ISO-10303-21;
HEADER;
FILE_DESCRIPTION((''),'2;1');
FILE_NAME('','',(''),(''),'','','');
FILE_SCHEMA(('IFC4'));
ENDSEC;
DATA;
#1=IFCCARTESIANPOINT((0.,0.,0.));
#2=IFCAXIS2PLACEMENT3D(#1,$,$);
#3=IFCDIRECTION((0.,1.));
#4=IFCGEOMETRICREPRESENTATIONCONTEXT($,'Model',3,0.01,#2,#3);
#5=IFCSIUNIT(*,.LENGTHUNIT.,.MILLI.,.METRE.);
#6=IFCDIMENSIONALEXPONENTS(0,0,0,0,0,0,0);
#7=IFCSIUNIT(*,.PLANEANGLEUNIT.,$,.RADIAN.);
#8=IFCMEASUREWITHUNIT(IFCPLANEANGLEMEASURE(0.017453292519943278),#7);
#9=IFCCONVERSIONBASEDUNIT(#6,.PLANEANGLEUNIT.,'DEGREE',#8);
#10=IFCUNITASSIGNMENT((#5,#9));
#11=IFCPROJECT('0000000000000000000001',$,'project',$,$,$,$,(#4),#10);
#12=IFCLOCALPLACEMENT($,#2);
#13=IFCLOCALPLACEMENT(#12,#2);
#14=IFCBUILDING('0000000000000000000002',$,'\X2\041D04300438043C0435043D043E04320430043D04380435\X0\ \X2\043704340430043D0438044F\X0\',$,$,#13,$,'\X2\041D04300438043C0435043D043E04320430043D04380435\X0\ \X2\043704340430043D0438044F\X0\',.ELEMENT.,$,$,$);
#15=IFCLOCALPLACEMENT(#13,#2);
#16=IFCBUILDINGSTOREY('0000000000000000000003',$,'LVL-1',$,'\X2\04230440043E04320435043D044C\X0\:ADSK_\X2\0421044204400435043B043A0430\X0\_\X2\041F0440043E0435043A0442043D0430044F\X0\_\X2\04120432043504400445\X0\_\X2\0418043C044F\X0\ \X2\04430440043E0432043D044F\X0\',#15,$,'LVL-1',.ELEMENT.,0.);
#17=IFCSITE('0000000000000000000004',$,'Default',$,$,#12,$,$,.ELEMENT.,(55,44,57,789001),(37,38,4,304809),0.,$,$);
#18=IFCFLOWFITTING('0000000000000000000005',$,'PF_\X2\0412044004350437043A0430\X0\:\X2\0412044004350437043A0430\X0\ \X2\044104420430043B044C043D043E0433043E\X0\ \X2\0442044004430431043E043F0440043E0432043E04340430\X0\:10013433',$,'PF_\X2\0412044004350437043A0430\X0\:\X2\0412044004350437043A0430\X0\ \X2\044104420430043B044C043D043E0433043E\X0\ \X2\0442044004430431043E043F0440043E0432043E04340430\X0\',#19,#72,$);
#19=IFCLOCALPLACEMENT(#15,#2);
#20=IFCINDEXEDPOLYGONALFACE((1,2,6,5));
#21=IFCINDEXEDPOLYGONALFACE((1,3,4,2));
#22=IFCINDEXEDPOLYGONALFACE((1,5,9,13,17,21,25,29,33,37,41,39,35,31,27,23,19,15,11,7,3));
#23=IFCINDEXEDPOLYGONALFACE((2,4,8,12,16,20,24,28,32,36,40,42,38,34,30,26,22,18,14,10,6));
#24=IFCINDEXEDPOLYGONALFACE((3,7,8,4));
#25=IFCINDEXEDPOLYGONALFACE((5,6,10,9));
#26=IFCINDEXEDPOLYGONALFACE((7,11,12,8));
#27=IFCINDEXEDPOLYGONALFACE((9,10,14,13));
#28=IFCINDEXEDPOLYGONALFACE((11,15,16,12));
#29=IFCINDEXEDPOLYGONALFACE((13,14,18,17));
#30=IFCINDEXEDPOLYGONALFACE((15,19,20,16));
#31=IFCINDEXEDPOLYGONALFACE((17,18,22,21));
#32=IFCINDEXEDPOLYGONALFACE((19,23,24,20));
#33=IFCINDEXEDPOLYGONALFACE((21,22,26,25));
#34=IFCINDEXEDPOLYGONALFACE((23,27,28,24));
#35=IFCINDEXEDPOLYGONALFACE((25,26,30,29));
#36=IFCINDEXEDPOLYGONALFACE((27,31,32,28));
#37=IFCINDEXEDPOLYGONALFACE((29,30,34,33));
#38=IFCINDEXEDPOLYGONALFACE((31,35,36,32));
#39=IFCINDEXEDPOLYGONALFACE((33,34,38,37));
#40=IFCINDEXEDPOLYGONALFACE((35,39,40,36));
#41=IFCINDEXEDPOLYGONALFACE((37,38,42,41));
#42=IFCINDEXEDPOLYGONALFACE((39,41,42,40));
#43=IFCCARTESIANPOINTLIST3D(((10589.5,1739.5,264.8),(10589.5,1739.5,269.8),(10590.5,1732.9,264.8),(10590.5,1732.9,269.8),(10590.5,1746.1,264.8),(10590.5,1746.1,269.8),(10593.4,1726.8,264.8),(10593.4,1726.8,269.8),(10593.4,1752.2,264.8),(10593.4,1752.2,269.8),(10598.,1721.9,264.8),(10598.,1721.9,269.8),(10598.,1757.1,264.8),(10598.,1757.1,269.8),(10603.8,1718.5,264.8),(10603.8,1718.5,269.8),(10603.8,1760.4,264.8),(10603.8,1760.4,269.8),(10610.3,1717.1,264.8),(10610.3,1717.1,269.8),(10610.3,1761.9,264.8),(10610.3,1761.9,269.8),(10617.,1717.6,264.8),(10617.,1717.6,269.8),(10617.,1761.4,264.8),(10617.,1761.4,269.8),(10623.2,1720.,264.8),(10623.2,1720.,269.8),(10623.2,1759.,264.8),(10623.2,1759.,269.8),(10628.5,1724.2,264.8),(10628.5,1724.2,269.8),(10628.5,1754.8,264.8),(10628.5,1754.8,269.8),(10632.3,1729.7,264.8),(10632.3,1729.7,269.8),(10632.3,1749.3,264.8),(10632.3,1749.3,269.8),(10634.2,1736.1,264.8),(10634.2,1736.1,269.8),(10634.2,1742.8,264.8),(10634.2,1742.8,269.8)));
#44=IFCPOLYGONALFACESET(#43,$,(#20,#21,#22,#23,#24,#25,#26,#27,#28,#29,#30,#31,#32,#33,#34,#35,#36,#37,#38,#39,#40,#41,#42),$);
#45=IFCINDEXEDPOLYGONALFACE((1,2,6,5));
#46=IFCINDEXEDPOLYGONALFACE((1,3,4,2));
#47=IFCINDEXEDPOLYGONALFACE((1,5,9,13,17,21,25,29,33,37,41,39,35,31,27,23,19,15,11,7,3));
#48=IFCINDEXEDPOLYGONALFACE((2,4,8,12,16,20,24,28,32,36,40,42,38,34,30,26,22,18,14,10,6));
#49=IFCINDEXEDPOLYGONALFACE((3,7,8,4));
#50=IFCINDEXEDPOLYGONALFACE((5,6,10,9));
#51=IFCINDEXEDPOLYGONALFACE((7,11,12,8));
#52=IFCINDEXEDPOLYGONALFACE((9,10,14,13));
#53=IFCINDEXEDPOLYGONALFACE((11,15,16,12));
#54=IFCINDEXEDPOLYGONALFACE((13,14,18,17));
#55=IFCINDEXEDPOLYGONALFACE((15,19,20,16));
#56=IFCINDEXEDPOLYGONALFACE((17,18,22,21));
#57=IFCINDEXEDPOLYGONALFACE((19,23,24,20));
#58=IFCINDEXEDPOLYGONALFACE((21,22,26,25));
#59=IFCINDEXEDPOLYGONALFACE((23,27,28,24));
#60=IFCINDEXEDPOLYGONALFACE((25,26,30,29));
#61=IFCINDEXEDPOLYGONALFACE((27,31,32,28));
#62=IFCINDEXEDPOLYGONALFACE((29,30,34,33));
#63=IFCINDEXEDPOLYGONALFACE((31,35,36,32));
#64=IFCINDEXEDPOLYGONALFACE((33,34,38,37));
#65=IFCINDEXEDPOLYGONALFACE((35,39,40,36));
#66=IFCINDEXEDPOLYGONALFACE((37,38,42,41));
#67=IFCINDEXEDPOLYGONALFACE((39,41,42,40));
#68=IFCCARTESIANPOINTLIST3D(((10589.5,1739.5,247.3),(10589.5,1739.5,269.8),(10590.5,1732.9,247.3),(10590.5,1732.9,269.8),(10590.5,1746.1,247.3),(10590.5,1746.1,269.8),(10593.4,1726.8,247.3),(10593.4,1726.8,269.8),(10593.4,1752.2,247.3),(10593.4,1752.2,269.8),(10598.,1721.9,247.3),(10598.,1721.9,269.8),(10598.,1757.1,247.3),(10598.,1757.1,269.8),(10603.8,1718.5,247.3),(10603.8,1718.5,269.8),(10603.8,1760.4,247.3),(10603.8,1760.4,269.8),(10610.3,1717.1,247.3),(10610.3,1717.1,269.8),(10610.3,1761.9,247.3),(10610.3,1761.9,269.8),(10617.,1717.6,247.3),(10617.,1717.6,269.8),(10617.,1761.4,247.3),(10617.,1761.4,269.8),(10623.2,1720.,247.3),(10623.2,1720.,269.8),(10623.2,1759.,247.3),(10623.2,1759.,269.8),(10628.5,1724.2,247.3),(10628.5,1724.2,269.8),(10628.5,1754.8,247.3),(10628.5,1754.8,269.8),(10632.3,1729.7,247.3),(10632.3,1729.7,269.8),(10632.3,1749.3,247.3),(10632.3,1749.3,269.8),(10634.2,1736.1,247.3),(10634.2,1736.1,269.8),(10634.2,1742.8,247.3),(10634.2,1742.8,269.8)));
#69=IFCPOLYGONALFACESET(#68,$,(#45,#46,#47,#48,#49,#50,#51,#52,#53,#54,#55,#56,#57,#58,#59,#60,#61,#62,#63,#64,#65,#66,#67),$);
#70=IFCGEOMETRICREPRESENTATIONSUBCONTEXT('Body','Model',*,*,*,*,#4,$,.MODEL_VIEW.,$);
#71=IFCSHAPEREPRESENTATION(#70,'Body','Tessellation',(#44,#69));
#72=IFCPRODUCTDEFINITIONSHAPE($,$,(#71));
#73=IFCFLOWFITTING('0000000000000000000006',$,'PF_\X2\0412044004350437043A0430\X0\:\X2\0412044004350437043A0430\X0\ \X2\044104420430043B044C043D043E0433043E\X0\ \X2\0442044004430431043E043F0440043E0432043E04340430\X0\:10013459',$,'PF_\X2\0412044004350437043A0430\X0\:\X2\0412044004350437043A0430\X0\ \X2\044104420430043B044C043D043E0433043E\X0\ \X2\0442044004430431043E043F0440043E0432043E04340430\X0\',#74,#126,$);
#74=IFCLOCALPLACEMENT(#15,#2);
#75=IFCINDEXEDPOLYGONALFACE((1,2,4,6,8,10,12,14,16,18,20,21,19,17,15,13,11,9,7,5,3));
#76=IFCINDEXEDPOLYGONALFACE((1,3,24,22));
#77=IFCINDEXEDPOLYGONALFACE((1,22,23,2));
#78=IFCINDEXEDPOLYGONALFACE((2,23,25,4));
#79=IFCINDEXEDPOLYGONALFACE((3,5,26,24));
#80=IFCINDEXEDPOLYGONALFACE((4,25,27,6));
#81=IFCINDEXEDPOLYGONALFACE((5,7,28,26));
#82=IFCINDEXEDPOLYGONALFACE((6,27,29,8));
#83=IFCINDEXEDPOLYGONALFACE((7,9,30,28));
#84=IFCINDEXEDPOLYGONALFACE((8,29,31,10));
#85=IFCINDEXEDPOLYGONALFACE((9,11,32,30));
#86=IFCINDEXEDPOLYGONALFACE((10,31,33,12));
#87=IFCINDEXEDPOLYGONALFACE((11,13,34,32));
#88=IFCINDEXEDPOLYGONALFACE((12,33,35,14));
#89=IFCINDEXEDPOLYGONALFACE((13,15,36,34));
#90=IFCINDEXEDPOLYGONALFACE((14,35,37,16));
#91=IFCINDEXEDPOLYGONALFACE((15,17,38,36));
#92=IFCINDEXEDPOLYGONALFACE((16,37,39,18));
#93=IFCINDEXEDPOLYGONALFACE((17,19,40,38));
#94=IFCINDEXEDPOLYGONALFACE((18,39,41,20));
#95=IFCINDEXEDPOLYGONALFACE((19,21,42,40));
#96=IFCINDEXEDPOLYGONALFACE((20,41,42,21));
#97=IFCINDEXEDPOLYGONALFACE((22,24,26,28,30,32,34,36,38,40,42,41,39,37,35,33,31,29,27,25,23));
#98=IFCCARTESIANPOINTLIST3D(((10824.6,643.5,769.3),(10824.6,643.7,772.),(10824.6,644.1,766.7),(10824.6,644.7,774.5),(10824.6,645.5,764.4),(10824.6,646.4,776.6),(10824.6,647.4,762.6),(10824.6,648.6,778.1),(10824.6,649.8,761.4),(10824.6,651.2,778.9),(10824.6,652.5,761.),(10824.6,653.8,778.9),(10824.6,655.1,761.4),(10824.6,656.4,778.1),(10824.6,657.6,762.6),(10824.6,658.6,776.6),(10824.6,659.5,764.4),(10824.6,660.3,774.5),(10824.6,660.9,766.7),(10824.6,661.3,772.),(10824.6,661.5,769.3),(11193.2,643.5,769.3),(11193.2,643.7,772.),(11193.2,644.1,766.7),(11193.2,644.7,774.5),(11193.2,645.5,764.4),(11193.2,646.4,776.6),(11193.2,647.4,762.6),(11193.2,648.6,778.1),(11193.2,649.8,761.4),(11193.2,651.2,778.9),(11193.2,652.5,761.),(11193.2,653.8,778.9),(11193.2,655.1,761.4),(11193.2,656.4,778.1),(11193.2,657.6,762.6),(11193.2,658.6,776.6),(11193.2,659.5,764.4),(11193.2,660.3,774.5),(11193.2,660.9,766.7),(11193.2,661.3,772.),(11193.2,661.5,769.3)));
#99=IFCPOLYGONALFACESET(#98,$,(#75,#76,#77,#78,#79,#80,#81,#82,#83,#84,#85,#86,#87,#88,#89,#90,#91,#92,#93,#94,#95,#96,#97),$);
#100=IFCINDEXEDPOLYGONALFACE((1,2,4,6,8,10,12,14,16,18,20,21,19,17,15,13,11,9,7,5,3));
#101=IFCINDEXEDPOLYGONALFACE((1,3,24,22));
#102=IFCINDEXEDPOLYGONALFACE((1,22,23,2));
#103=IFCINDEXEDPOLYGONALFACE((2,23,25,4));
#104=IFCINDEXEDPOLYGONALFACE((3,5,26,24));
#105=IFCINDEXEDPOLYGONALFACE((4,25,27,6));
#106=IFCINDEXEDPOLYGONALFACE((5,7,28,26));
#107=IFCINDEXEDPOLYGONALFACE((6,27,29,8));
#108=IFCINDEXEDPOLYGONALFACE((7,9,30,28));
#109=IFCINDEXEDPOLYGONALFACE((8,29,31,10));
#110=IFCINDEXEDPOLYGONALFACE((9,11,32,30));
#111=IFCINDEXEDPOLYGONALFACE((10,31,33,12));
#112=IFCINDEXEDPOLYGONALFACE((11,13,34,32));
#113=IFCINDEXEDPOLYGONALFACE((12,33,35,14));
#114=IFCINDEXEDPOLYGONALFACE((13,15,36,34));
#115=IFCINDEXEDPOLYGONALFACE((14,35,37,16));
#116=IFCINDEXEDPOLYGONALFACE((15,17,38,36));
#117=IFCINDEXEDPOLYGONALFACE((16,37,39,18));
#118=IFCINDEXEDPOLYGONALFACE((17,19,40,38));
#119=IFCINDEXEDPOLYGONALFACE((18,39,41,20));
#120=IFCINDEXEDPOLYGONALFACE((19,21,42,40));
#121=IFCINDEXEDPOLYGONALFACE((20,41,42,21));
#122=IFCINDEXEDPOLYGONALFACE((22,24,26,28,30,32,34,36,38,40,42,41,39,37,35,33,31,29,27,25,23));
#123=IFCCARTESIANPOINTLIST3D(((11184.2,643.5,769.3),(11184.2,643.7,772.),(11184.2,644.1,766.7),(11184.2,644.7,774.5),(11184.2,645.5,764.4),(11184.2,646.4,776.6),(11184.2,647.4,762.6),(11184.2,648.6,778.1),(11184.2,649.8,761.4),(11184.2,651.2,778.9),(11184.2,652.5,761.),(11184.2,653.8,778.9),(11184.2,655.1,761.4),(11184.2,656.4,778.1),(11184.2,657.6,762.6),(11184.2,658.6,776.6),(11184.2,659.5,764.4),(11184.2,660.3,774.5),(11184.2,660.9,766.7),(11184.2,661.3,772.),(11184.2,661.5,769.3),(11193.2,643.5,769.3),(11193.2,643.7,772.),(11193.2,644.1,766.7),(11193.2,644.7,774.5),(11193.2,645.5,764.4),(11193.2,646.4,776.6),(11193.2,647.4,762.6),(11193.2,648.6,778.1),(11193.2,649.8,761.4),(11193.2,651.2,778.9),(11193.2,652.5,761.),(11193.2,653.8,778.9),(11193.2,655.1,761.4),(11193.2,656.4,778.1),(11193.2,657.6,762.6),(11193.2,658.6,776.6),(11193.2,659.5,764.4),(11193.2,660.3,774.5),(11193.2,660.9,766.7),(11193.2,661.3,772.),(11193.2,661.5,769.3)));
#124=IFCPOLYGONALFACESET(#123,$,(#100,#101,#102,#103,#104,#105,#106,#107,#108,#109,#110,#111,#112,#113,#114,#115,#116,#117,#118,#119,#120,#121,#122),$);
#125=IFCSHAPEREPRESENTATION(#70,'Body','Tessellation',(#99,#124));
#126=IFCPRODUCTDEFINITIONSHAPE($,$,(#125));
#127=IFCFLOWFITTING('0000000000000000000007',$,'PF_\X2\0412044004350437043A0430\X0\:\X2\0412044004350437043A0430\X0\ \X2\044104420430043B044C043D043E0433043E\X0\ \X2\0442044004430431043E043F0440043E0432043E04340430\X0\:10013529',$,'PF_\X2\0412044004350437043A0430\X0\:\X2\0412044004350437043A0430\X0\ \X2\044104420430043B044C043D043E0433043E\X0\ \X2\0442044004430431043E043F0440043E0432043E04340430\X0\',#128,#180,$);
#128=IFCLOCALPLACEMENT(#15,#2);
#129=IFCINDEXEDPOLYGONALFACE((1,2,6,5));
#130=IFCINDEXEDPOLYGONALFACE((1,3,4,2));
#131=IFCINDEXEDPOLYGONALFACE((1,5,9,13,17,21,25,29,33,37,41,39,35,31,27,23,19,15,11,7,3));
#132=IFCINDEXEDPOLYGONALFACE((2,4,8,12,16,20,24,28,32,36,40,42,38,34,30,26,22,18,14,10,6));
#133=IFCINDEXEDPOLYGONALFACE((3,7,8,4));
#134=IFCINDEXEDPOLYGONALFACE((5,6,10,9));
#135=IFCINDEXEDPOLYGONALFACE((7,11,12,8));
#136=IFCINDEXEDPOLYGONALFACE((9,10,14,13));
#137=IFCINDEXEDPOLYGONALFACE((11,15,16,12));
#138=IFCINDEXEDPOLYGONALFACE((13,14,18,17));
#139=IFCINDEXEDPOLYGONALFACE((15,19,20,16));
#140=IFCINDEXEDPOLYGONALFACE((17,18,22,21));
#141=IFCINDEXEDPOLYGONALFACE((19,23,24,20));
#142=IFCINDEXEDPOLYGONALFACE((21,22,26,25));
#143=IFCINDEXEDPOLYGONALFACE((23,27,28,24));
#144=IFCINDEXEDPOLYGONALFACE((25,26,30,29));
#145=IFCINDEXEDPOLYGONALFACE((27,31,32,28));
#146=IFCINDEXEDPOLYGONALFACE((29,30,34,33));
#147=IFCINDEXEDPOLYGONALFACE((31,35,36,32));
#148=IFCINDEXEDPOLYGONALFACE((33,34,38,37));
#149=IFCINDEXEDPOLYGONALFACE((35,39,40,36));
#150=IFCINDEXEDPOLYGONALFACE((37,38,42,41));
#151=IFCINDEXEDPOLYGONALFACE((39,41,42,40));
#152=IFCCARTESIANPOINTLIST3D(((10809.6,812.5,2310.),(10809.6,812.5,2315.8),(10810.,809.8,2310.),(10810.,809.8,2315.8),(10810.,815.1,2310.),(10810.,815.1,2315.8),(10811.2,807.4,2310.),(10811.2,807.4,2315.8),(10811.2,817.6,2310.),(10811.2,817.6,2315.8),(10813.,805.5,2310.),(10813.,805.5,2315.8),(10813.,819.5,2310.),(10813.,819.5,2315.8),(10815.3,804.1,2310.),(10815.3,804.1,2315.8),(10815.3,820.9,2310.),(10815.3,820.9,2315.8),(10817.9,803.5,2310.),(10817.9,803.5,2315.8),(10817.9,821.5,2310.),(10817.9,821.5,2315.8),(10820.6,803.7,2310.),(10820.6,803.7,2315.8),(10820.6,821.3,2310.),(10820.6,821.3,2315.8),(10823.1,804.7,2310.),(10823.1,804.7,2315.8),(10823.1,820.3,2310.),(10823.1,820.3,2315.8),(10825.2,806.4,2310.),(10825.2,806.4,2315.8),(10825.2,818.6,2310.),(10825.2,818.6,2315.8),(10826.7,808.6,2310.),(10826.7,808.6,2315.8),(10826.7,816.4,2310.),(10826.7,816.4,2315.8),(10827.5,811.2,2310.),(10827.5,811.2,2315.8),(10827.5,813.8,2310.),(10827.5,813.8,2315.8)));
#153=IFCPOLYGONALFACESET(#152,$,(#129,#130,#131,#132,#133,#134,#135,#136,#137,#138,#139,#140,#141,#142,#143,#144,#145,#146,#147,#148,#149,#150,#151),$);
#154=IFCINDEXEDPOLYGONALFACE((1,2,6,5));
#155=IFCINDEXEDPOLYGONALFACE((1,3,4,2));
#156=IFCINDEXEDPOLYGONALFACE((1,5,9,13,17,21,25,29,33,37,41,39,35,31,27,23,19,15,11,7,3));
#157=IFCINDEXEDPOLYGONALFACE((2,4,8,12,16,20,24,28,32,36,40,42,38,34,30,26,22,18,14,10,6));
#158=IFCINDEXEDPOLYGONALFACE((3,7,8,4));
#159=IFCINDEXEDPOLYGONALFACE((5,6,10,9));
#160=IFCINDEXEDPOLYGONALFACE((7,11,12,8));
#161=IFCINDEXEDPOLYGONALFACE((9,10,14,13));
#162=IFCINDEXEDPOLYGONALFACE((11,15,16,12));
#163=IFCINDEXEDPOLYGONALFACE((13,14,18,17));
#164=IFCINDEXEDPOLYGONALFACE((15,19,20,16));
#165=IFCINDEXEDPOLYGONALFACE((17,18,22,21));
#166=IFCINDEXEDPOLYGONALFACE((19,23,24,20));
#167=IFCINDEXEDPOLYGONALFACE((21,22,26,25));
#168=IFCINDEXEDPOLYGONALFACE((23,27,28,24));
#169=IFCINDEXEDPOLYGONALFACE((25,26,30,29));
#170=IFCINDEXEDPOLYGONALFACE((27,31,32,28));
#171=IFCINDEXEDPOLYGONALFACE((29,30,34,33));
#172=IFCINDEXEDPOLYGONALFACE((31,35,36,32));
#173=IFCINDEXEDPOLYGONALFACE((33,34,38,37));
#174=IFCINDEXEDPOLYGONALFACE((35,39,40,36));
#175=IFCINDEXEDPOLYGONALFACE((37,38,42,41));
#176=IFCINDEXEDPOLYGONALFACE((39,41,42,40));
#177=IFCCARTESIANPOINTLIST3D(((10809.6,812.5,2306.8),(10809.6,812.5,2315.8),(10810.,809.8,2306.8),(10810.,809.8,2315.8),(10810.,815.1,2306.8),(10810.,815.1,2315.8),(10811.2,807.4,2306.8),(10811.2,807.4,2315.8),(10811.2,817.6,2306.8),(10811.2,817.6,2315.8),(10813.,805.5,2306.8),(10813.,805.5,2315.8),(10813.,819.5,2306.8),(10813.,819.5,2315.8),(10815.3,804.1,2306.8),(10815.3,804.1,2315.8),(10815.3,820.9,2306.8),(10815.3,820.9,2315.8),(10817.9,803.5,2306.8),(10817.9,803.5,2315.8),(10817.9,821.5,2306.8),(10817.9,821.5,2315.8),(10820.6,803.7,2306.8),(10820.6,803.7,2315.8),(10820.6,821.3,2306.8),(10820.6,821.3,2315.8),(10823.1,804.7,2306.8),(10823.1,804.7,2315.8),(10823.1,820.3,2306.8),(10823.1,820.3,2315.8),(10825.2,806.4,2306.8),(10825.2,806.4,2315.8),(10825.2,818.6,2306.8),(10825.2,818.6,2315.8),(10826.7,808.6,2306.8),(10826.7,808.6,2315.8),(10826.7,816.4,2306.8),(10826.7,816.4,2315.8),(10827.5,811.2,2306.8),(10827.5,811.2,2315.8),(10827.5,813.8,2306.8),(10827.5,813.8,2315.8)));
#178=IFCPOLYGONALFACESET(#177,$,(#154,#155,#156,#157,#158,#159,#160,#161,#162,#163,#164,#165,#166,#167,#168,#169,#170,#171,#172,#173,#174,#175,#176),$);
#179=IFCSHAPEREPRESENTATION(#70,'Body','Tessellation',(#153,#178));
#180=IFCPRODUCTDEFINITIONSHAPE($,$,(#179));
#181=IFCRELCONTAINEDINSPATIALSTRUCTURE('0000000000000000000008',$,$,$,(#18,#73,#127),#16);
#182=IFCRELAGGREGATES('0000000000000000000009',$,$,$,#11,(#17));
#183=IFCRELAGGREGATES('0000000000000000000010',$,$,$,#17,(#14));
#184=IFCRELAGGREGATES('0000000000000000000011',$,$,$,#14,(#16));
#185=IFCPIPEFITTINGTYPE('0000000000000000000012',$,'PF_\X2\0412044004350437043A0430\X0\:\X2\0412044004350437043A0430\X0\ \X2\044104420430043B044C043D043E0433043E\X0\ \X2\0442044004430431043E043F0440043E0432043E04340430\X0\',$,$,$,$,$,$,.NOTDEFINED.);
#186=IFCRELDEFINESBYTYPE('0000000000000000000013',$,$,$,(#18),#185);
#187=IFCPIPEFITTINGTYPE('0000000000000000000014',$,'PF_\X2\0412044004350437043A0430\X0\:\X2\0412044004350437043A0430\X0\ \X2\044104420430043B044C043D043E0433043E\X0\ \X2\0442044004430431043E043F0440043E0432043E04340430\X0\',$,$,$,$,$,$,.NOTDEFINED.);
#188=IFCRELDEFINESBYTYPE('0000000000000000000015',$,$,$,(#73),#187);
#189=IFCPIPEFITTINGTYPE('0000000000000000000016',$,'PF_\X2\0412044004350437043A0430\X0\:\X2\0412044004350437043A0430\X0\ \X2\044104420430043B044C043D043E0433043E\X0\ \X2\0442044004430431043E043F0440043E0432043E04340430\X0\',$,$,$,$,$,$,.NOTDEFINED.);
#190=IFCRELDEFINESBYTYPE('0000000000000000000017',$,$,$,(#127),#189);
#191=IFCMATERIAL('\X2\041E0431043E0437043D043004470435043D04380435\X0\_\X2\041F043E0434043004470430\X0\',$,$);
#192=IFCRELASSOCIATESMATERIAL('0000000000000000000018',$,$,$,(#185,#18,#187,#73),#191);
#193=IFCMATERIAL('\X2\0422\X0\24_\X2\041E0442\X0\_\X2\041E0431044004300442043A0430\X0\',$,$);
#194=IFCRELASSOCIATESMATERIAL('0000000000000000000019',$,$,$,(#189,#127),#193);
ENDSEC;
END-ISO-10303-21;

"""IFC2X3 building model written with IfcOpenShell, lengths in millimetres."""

from ifc_helpers import new_model, entity, si_unit, converted_unit, direction, frame, frame_2d, origin, place, context, subcontext, project, spatial, circle, extrude, source, transform, mapped, material, type_object, type_shapes, element, save


model = new_model("IFC2X3")

# Units and contexts
model_context = context("Model", 3, precision=0.01, world=origin(), true_north=direction((0.0, 1.0)))
body_context = subcontext(model_context, "Body", "Model", "MODEL_VIEW")
ifc_project = project(units=[si_unit("LENGTHUNIT", "METRE", prefix="MILLI"), converted_unit("PLANEANGLEUNIT", "DEGREE", entity("IfcPlaneAngleMeasure", 0.017453292519943278), si_unit("PLANEANGLEUNIT", "RADIAN"), dimensions=[0, 0, 0, 0, 0, 0, 0])], contexts=[model_context])

# Site, building, storey
site_placement = place(None, origin())
site = spatial("IfcSite", under=ifc_project, at=site_placement, Name="Default", CompositionType="ELEMENT", RefLatitude=(55, 44, 57, 789001), RefLongitude=(37, 38, 4, 304809), RefElevation=0.0)
building_placement = place(site_placement, origin())
building = spatial("IfcBuilding", under=site, at=building_placement, Name="Наименование здания", LongName="Наименование здания", CompositionType="ELEMENT")
storey_placement = place(building_placement, origin())
storey = spatial("IfcBuildingStorey", under=building, at=storey_placement, Name="LVL-1", ObjectType="Уровень:ADSK_Стрелка_Проектная_Вверх_Имя уровня", LongName="LVL-1", CompositionType="ELEMENT", Elevation=0.0)

# Shared definitions
ifc_material_1 = material(Name="Обозначение_Подача")

# Flow fittings
ifc_material_2 = material(Name="Т24_От_Обратка")
pipe_fitting_type_1 = type_object("IfcPipeFittingType", Name="PF_Врезка:Врезка стального трубопровода", PredefinedType="NOTDEFINED", material=ifc_material_1)
shared_shape_1 = source(origin(), body_context, "Body", "SweptSolid", [
    extrude(circle(Radius=22.5, at=frame_2d((0.0, 0.0), x_axis=(1.0, 0.0))), frame((-5.0, 0.0, 0.0), z_axis=(1.0, 0.0, 0.0), x_axis=(0.0, 1.0, 0.0)), (0.0, 0.0, 1.0), 5.0),
    extrude(circle(Radius=22.5, at=frame_2d((0.0, 0.0), x_axis=(1.0, 0.0))), frame((-22.5, 0.0, 0.0), z_axis=(1.0, 0.0, 0.0), x_axis=(0.0, 1.0, 0.0)), (0.0, 0.0, 1.0), 22.5),
])
type_shapes(pipe_fitting_type_1, [shared_shape_1])
flow_fitting_1_placement = place(storey_placement, frame((10612.0, 1739.5, 269.8), z_axis=(0.0, -1.0, 0.0), x_axis=(0.0, 0.0, 1.0)))
element("IfcFlowFitting", 1, at=flow_fitting_1_placement, inside=storey, type_object=pipe_fitting_type_1, material=ifc_material_1, Name="PF_Врезка:Врезка стального трубопровода:10013433", ObjectType="PF_Врезка:Врезка стального трубопровода", context=body_context, shape_type="MappedRepresentation", body=[
    mapped(shared_shape_1, transform((0.0, 0.0, 0.0), scale=1.0)),
])
pipe_fitting_type_2 = type_object("IfcPipeFittingType", Name="PF_Врезка:Врезка стального трубопровода", PredefinedType="NOTDEFINED", material=ifc_material_1)
shared_shape_2 = source(origin(), body_context, "Body", "SweptSolid", [
    extrude(circle(Radius=9.0, at=frame_2d((0.0, 0.0), x_axis=(1.0, 0.0))), frame((-368.5, 0.0, 0.0), z_axis=(1.0, 0.0, 0.0), x_axis=(0.0, -1.0, 0.0)), (0.0, 0.0, 1.0), 368.5),
    extrude(circle(Radius=9.0, at=frame_2d((0.0, 0.0), x_axis=(1.0, 0.0))), frame((-9.0, 0.0, 0.0), z_axis=(1.0, 0.0, 0.0), x_axis=(0.0, -1.0, 0.0)), (0.0, 0.0, 1.0), 9.0),
])
type_shapes(pipe_fitting_type_2, [shared_shape_2])
flow_fitting_2_placement = place(storey_placement, frame((11193.2, 652.5, 770.0), z_axis=(0.0, -1.0, 0.0), x_axis=(1.0, 0.0, 0.0)))
element("IfcFlowFitting", 2, at=flow_fitting_2_placement, inside=storey, type_object=pipe_fitting_type_2, material=ifc_material_1, Name="PF_Врезка:Врезка стального трубопровода:10013459", ObjectType="PF_Врезка:Врезка стального трубопровода", context=body_context, shape_type="MappedRepresentation", body=[
    mapped(shared_shape_2, transform((0.0, 0.0, 0.0), scale=1.0)),
])
pipe_fitting_type_3 = type_object("IfcPipeFittingType", Name="PF_Врезка:Врезка стального трубопровода", PredefinedType="NOTDEFINED", material=ifc_material_2)
shared_shape_3 = source(origin(), body_context, "Body", "SweptSolid", [
    extrude(circle(Radius=9.0, at=frame_2d((0.0, 0.0), x_axis=(1.0, 0.0))), frame((-5.8, 0.0, 0.0), z_axis=(1.0, 0.0, 0.0), x_axis=(0.0, 1.0, 0.0)), (0.0, 0.0, 1.0), 5.8),
    extrude(circle(Radius=9.0, at=frame_2d((0.0, 0.0), x_axis=(1.0, 0.0))), frame((-9.0, 0.0, 0.0), z_axis=(1.0, 0.0, 0.0), x_axis=(0.0, 1.0, 0.0)), (0.0, 0.0, 1.0), 9.0),
])
type_shapes(pipe_fitting_type_3, [shared_shape_3])
flow_fitting_3_placement = place(storey_placement, frame((10818.6, 812.5, 2315.8), z_axis=(0.0, -1.0, 0.0), x_axis=(0.0, 0.0, 1.0)))
element("IfcFlowFitting", 3, at=flow_fitting_3_placement, inside=storey, type_object=pipe_fitting_type_3, material=ifc_material_2, Name="PF_Врезка:Врезка стального трубопровода:10013529", ObjectType="PF_Врезка:Врезка стального трубопровода", context=body_context, shape_type="MappedRepresentation", body=[
    mapped(shared_shape_3, transform((0.0, 0.0, 0.0), scale=1.0)),
])

save(model, "model.ifc")
